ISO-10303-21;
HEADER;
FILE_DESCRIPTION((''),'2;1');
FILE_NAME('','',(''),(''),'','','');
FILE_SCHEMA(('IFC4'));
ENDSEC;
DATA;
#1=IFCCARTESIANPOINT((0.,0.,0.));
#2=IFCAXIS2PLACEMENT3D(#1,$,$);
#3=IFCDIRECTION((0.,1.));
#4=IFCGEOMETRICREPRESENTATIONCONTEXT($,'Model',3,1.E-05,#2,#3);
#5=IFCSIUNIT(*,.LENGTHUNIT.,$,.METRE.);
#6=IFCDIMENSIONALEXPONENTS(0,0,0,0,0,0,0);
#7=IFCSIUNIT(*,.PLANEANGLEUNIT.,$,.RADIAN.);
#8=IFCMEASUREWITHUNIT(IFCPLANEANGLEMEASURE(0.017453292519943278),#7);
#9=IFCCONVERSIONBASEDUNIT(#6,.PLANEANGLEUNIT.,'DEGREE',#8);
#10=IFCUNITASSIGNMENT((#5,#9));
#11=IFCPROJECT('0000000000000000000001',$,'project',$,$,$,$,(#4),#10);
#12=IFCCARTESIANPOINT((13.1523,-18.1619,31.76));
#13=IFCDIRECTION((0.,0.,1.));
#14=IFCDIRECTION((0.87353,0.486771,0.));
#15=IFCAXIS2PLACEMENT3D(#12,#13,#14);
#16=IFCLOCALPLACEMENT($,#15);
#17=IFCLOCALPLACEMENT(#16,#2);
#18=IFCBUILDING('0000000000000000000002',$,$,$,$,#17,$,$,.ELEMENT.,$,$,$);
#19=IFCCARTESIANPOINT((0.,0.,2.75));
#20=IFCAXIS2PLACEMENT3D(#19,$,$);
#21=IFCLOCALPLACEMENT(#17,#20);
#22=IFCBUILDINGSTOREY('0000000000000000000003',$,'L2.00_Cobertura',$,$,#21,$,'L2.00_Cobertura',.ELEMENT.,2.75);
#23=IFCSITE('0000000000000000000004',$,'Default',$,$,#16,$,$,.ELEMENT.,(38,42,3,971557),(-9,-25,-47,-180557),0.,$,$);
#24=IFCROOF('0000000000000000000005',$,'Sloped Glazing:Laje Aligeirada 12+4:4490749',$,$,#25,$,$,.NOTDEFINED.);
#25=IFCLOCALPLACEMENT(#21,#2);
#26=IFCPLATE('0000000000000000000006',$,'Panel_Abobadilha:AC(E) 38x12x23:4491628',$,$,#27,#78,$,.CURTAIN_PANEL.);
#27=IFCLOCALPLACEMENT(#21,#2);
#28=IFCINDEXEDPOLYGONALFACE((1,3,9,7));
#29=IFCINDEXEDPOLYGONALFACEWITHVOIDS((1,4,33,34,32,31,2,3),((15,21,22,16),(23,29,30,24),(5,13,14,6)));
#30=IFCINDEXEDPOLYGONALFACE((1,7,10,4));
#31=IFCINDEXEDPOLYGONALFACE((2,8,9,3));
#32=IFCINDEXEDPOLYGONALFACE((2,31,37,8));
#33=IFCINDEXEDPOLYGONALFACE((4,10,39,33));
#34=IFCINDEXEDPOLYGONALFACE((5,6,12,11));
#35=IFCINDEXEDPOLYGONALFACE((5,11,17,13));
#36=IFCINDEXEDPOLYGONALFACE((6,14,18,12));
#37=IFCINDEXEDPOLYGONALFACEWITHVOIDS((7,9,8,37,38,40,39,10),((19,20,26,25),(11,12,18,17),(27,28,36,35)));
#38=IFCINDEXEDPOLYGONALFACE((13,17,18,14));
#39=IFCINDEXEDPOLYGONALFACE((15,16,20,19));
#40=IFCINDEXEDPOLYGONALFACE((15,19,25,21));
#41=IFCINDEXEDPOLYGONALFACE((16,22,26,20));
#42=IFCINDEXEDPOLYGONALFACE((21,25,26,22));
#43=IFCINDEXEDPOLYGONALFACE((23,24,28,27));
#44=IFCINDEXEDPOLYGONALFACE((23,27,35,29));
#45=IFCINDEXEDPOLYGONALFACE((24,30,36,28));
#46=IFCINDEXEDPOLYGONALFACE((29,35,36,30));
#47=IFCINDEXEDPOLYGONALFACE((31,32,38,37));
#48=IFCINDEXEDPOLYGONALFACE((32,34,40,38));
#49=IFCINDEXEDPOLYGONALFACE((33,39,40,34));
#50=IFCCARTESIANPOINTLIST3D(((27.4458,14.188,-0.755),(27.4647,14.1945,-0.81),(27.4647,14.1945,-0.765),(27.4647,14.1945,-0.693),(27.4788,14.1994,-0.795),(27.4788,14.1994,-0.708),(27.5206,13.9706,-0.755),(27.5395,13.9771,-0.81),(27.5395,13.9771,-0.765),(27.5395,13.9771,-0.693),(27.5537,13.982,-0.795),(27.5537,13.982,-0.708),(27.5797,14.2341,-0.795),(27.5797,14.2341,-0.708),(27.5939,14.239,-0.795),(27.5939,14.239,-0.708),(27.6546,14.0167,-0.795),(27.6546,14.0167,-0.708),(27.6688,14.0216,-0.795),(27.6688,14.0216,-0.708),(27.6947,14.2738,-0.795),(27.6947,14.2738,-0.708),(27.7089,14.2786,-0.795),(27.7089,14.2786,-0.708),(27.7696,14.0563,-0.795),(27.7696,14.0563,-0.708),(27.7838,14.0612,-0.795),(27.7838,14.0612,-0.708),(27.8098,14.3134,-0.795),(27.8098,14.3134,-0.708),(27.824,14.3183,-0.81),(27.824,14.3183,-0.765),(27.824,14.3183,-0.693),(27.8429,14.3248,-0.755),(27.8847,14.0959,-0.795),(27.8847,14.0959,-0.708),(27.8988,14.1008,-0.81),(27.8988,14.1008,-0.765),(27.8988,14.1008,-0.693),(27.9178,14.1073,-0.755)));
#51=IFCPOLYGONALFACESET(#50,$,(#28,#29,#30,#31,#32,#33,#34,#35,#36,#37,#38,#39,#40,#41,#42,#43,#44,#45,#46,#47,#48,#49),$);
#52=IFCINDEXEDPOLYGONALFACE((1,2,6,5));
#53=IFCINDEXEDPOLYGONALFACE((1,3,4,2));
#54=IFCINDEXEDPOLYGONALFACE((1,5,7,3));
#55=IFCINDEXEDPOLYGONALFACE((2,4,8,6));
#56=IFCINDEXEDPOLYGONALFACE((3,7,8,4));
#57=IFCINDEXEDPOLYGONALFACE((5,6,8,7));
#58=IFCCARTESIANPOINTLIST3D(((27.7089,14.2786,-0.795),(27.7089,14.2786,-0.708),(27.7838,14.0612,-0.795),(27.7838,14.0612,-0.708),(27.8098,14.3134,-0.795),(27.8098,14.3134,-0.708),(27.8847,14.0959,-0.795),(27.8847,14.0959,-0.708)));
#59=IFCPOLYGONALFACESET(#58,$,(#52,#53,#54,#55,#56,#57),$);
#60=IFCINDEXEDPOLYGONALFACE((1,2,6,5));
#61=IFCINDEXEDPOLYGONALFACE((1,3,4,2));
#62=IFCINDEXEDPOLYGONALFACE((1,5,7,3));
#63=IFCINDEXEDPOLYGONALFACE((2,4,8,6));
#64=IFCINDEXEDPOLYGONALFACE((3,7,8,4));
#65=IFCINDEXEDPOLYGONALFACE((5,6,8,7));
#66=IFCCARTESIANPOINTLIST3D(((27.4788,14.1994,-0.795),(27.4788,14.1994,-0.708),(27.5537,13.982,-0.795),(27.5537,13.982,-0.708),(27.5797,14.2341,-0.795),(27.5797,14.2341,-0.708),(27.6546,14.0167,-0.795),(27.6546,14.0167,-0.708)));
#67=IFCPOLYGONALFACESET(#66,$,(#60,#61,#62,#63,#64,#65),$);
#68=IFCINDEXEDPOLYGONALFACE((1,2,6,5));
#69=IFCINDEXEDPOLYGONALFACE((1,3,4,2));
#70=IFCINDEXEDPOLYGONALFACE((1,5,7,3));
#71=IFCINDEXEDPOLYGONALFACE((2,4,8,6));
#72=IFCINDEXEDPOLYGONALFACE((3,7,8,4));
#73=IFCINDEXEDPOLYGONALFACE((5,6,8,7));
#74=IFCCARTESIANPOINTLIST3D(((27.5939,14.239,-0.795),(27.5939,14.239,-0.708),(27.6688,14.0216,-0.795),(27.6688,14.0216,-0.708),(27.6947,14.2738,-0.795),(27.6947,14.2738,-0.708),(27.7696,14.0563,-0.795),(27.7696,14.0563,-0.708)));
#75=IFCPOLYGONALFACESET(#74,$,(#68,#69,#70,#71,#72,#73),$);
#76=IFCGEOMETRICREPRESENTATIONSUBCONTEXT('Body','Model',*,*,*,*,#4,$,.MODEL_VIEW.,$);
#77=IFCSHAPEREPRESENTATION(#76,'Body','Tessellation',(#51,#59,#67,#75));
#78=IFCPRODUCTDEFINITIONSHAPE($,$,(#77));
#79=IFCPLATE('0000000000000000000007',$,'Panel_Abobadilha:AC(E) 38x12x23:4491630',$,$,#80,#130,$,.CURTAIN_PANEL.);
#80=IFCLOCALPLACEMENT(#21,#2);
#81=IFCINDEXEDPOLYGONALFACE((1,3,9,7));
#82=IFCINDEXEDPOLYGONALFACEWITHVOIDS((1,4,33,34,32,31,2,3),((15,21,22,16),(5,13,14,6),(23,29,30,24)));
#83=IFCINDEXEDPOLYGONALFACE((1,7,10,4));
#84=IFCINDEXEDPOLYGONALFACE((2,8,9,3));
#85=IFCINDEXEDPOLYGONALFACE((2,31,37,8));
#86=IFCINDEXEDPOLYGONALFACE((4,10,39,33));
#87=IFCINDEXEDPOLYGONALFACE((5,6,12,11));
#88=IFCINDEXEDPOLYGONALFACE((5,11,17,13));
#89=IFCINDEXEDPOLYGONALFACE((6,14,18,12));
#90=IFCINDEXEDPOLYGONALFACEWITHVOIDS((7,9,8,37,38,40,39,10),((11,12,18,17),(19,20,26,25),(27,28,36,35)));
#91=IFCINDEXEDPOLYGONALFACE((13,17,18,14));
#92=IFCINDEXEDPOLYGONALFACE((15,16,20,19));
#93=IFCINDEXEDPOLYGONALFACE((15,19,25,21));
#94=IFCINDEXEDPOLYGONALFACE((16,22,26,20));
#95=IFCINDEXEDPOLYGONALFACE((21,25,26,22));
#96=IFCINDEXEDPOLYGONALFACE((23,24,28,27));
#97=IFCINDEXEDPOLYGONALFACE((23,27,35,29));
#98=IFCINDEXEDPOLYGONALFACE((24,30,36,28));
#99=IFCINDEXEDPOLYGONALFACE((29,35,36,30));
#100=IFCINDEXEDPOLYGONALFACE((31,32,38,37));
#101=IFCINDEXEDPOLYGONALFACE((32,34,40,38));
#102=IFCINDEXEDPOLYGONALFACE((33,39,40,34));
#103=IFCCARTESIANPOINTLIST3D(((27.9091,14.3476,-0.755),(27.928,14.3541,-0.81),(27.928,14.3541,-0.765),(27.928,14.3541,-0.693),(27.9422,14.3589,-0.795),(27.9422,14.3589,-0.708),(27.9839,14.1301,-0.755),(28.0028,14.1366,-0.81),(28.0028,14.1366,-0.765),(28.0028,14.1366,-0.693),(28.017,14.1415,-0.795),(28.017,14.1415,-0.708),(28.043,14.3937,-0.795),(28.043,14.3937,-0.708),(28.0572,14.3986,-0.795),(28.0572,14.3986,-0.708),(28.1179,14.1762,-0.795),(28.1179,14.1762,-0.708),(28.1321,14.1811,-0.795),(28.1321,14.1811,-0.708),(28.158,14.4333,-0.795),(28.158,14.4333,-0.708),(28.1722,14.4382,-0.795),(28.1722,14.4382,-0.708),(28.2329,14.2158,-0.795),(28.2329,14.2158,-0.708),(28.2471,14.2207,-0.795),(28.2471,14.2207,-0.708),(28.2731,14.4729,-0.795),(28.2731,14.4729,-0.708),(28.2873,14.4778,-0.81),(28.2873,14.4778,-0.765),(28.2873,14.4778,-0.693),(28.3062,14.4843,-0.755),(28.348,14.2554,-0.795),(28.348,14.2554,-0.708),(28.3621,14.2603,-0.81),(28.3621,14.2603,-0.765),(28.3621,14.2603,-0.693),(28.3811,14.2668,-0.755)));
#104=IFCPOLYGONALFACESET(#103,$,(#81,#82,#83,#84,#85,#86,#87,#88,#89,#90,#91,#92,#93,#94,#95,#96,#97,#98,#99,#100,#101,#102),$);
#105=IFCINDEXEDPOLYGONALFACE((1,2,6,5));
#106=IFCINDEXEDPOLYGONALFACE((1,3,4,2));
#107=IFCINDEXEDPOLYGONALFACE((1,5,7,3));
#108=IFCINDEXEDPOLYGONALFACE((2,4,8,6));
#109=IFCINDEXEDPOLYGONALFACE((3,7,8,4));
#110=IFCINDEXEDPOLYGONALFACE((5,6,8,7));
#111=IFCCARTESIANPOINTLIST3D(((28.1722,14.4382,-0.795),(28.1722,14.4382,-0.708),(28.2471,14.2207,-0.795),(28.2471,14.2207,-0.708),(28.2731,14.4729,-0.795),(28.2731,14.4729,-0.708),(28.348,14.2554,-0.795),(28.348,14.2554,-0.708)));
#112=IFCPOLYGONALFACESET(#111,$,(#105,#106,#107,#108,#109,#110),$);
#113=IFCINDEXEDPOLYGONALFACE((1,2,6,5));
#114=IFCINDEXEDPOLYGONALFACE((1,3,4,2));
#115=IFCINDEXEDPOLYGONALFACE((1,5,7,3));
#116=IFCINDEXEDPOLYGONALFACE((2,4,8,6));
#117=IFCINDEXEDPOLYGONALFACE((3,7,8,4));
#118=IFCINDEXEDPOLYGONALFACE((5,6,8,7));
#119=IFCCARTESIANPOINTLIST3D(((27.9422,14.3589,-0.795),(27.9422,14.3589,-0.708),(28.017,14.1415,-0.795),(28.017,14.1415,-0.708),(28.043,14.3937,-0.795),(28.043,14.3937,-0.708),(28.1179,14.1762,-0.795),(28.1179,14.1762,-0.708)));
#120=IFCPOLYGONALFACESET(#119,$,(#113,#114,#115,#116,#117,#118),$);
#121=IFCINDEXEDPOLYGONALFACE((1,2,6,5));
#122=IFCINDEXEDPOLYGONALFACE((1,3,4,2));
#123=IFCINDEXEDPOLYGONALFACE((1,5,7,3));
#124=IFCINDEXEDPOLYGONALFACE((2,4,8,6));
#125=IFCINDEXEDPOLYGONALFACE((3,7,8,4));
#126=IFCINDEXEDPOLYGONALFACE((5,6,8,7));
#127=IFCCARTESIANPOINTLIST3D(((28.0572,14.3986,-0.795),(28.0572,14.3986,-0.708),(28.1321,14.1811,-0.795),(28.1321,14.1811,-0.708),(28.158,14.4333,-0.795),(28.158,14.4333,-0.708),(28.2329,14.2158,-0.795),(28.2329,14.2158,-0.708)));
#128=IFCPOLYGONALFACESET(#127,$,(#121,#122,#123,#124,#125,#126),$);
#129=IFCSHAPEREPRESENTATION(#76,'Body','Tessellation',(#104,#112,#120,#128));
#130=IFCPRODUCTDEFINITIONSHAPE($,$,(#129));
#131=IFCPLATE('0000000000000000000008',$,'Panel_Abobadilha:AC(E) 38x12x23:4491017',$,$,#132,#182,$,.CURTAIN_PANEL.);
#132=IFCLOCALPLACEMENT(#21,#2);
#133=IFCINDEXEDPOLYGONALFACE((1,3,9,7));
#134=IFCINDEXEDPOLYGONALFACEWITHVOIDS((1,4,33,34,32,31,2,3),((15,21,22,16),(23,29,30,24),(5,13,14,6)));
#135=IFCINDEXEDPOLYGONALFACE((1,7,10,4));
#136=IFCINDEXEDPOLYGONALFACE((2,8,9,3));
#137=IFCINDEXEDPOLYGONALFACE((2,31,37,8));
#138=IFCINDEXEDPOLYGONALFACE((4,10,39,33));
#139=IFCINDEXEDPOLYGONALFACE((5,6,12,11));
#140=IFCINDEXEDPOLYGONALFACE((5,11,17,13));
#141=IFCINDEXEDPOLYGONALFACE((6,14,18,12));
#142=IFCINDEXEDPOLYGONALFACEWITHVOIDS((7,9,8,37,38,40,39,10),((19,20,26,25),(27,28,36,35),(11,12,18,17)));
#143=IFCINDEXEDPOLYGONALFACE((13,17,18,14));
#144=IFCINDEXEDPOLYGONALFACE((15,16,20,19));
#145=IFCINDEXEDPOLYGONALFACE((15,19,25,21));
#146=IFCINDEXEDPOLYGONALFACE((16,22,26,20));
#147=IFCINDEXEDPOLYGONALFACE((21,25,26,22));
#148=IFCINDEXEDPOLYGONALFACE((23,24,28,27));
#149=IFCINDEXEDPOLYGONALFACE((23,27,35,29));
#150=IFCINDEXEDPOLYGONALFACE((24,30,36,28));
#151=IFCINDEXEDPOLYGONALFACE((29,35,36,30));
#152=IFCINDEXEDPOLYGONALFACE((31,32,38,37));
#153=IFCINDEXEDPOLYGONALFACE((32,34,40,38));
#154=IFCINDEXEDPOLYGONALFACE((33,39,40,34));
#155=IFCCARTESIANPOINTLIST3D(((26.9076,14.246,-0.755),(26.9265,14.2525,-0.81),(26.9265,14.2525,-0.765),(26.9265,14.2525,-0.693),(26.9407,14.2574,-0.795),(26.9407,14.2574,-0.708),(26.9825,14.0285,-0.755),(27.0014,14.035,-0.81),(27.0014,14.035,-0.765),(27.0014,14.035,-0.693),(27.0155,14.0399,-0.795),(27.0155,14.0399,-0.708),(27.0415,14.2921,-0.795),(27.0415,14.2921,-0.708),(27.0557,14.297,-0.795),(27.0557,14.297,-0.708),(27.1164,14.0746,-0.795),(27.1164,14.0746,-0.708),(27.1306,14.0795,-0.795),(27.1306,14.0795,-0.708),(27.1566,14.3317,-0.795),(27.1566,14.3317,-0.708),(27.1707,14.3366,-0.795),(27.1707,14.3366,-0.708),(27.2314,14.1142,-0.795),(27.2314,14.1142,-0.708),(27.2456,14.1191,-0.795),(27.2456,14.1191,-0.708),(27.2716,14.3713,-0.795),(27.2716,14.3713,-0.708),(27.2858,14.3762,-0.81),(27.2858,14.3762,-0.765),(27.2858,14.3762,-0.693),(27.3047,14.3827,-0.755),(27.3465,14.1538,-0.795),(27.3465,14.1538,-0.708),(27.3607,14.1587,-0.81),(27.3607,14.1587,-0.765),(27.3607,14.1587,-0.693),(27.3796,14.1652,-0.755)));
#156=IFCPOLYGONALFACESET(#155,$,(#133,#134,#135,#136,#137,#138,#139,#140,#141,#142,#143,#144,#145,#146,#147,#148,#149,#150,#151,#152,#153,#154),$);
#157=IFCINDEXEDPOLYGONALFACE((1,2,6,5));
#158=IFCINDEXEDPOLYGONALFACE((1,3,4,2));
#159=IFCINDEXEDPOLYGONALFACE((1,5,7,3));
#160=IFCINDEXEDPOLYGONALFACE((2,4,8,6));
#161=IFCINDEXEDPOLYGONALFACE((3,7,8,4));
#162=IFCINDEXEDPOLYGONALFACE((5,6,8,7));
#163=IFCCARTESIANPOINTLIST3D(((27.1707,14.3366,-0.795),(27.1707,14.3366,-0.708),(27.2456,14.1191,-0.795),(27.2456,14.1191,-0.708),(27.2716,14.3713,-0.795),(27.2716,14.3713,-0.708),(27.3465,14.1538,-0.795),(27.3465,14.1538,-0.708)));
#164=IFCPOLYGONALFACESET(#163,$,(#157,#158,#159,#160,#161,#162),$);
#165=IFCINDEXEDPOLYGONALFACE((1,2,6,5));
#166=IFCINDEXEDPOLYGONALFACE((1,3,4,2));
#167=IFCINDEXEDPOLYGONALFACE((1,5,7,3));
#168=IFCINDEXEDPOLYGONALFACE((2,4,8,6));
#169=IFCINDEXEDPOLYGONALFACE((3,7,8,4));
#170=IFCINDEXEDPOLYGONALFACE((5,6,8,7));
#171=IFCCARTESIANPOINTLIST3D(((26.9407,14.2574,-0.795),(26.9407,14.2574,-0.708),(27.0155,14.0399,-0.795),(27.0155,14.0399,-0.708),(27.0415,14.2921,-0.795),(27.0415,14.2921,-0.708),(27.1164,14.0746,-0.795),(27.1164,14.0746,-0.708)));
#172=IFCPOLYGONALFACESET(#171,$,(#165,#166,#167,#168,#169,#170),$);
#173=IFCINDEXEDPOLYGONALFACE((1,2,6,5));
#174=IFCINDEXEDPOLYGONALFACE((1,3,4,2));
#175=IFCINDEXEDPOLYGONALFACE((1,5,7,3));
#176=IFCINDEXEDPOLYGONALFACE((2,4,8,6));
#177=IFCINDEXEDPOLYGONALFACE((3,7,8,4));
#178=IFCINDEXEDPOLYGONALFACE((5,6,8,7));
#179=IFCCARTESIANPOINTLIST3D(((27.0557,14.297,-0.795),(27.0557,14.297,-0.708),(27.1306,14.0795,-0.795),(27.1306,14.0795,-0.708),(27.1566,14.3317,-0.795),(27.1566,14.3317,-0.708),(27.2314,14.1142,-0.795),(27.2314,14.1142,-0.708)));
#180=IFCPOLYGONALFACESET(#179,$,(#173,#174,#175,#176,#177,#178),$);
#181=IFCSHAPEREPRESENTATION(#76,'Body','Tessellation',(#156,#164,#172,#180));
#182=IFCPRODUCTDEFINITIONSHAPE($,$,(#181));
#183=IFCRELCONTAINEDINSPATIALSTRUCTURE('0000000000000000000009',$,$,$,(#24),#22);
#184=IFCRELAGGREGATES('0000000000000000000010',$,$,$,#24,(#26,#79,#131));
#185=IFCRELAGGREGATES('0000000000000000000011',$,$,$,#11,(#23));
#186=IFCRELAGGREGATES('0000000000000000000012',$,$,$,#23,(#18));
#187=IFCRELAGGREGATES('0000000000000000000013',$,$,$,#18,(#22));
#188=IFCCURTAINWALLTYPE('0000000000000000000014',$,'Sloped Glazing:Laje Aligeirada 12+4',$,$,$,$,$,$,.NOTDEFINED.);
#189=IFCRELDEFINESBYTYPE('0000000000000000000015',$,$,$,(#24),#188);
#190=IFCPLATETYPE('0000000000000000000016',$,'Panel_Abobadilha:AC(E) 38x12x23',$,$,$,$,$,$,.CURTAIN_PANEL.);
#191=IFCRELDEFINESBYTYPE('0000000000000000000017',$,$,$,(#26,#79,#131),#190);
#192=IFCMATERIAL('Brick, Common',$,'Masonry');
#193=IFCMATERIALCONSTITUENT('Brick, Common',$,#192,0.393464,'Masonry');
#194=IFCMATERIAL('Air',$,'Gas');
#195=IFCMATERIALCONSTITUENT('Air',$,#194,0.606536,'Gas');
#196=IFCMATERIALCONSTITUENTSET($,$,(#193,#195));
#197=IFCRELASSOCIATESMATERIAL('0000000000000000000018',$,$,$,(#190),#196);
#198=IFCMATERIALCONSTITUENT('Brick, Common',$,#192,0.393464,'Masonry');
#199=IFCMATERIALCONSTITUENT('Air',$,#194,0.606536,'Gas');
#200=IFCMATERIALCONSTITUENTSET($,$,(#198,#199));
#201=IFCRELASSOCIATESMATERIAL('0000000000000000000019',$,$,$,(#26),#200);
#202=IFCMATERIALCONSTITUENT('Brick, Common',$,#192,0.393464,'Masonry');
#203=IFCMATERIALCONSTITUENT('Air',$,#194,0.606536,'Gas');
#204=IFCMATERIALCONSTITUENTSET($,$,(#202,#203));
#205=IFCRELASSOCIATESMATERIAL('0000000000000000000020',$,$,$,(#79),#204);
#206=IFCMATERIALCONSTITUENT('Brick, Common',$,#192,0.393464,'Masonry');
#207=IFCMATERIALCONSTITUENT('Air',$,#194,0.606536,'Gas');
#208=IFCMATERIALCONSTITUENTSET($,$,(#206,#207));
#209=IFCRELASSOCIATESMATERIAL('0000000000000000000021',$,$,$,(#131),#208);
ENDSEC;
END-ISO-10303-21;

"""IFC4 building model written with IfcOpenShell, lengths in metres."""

from ifc_helpers import new_model, entity, si_unit, converted_unit, direction, frame, origin, place, context, subcontext, project, spatial, indexed_curve, outline, extrude, source, transform, mapped, material, constituent, constituent_set, type_object, type_shapes, element, aggregate, save


model = new_model("IFC4")

# Units and contexts
model_context = context("Model", 3, precision=1e-05, world=origin(), true_north=direction((0.0, 1.0)))
body_context = subcontext(model_context, "Body", "Model", "MODEL_VIEW")
ifc_project = project(units=[si_unit("LENGTHUNIT", "METRE"), converted_unit("PLANEANGLEUNIT", "DEGREE", entity("IfcPlaneAngleMeasure", 0.017453292519943278), si_unit("PLANEANGLEUNIT", "RADIAN"), dimensions=[0, 0, 0, 0, 0, 0, 0])], contexts=[model_context])

# Site, building, storey
site_placement = place(None, frame((13.1523, -18.1619, 31.76), z_axis=(0.0, 0.0, 1.0), x_axis=(0.87353, 0.486771, 0.0)))
site = spatial("IfcSite", under=ifc_project, at=site_placement, Name="Default", CompositionType="ELEMENT", RefLatitude=(38, 42, 3, 971557), RefLongitude=(-9, -25, -47, -180557), RefElevation=0.0)
building_placement = place(site_placement, origin())
building = spatial("IfcBuilding", under=site, at=building_placement, CompositionType="ELEMENT")
storey_placement = place(building_placement, frame((0.0, 0.0, 2.75)))
storey = spatial("IfcBuildingStorey", under=building, at=storey_placement, Name="L2.00_Cobertura", LongName="L2.00_Cobertura", CompositionType="ELEMENT", Elevation=2.75)

# Roof, plates
curtain_wall_type = type_object("IfcCurtainWallType", Name="Sloped Glazing:Laje Aligeirada 12+4", PredefinedType="NOTDEFINED")
roof_placement = place(storey_placement, frame((0.0, 0.0, -2.75)))
roof = element("IfcRoof", 1, at=roof_placement, inside=storey, type_object=curtain_wall_type, Name="Sloped Glazing:Laje Aligeirada 12+4:4490749", PredefinedType="NOTDEFINED")
ifc_material_1 = material(Name="Brick, Common", Category="Masonry")
ifc_material_2 = material(Name="Air", Category="Gas")
ifc_constituent_1 = constituent(ifc_material_1, Name="Brick, Common", Category="Masonry", fraction=0.393464)
ifc_constituent_2 = constituent(ifc_material_2, Name="Air", Category="Gas", fraction=0.606536)
ifc_constituent_set_1 = constituent_set(constituents=[ifc_constituent_1, ifc_constituent_2])
plate_type = type_object("IfcPlateType", Name="Panel_Abobadilha:AC(E) 38x12x23", PredefinedType="CURTAIN_PANEL", material=ifc_constituent_set_1)
shared_shape_1 = source(origin(), body_context, "Body", "SweptSolid", [
    extrude(outline(indexed_curve([(-0.19, -0.0543), (0.19, -0.0543), (0.19, -0.0093), (0.21, 0.0007), (0.19, 0.0628), (-0.19, 0.0628), (-0.21, 0.0007), (-0.19, -0.0093), (-0.19, -0.0543)], self_intersect=False), holes=[indexed_curve([(-0.0683, 0.0477), (-0.0683, -0.0393), (-0.175, -0.0393), (-0.175, 0.0477), (-0.0683, 0.0477)], self_intersect=False), indexed_curve([(0.0533, 0.0477), (0.0533, -0.0393), (-0.0533, -0.0393), (-0.0533, 0.0477), (0.0533, 0.0477)], self_intersect=False), indexed_curve([(0.175, 0.0477), (0.175, -0.0393), (0.0683, -0.0393), (0.0683, 0.0477), (0.175, 0.0477)], self_intersect=False)]), frame((0.0, 0.0543, 0.0)), (0.0, 0.0, 1.0), 0.23),
    extrude(outline(indexed_curve([(-0.0533, -0.0435), (0.0533, -0.0435), (0.0533, 0.0435), (-0.0533, 0.0435), (-0.0533, -0.0435)], self_intersect=False)), frame((0.1217, 0.0585, 0.0), z_axis=(0.0, 0.0, 1.0), x_axis=(-1.0, 0.0, 0.0)), (0.0, 0.0, 1.0), 0.23),
    extrude(outline(indexed_curve([(-0.0533, -0.0435), (0.0533, -0.0435), (0.0533, 0.0435), (-0.0533, 0.0435), (-0.0533, -0.0435)], self_intersect=False)), frame((-0.1217, 0.0585, 0.0), z_axis=(0.0, 0.0, 1.0), x_axis=(-1.0, 0.0, 0.0)), (0.0, 0.0, 1.0), 0.23),
    extrude(outline(indexed_curve([(-0.0533, -0.0435), (0.0533, -0.0435), (0.0533, 0.0435), (-0.0533, 0.0435), (-0.0533, -0.0435)], self_intersect=False)), frame((0.0, 0.0585, 0.0), z_axis=(0.0, 0.0, 1.0), x_axis=(-1.0, 0.0, 0.0)), (0.0, 0.0, 1.0), 0.23),
])
type_shapes(plate_type, [shared_shape_1])
ifc_constituent_3 = constituent(ifc_material_1, Name="Brick, Common", Category="Masonry", fraction=0.393464)
ifc_constituent_4 = constituent(ifc_material_2, Name="Air", Category="Gas", fraction=0.606536)
ifc_constituent_set_2 = constituent_set(constituents=[ifc_constituent_3, ifc_constituent_4])
plate_1_placement = place(roof_placement, frame((27.6443, 14.2564, 1.94), z_axis=(0.325568, -0.945519, 0.0), x_axis=(0.945519, 0.325568, 0.0)))
plate_1 = element("IfcPlate", 2, at=plate_1_placement, type_object=plate_type, material=ifc_constituent_set_2, Name="Panel_Abobadilha:AC(E) 38x12x23:4491628", PredefinedType="CURTAIN_PANEL", context=body_context, shape_type="MappedRepresentation", body=[
    mapped(shared_shape_1, transform((0.0, 0.0, 0.0), scale=1.0)),
])
ifc_constituent_5 = constituent(ifc_material_1, Name="Brick, Common", Category="Masonry", fraction=0.393464)
ifc_constituent_6 = constituent(ifc_material_2, Name="Air", Category="Gas", fraction=0.606536)
ifc_constituent_set_3 = constituent_set(constituents=[ifc_constituent_5, ifc_constituent_6])
plate_2_placement = place(roof_placement, frame((28.1076, 14.4159, 1.94), z_axis=(0.325568, -0.945519, 0.0), x_axis=(0.945519, 0.325568, 0.0)))
plate_2 = element("IfcPlate", 3, at=plate_2_placement, type_object=plate_type, material=ifc_constituent_set_3, Name="Panel_Abobadilha:AC(E) 38x12x23:4491630", PredefinedType="CURTAIN_PANEL", context=body_context, shape_type="MappedRepresentation", body=[
    mapped(shared_shape_1, transform((0.0, 0.0, 0.0), scale=1.0)),
])
ifc_constituent_7 = constituent(ifc_material_1, Name="Brick, Common", Category="Masonry", fraction=0.393464)
ifc_constituent_8 = constituent(ifc_material_2, Name="Air", Category="Gas", fraction=0.606536)
ifc_constituent_set_4 = constituent_set(constituents=[ifc_constituent_7, ifc_constituent_8])
plate_3_placement = place(roof_placement, frame((27.1061, 14.3143, 1.94), z_axis=(0.325568, -0.945519, 0.0), x_axis=(0.945519, 0.325568, 0.0)))
plate_3 = element("IfcPlate", 4, at=plate_3_placement, type_object=plate_type, material=ifc_constituent_set_4, Name="Panel_Abobadilha:AC(E) 38x12x23:4491017", PredefinedType="CURTAIN_PANEL", context=body_context, shape_type="MappedRepresentation", body=[
    mapped(shared_shape_1, transform((0.0, 0.0, 0.0), scale=1.0)),
])
aggregate(roof, [plate_1, plate_2, plate_3])

save(model, "model.ifc")
